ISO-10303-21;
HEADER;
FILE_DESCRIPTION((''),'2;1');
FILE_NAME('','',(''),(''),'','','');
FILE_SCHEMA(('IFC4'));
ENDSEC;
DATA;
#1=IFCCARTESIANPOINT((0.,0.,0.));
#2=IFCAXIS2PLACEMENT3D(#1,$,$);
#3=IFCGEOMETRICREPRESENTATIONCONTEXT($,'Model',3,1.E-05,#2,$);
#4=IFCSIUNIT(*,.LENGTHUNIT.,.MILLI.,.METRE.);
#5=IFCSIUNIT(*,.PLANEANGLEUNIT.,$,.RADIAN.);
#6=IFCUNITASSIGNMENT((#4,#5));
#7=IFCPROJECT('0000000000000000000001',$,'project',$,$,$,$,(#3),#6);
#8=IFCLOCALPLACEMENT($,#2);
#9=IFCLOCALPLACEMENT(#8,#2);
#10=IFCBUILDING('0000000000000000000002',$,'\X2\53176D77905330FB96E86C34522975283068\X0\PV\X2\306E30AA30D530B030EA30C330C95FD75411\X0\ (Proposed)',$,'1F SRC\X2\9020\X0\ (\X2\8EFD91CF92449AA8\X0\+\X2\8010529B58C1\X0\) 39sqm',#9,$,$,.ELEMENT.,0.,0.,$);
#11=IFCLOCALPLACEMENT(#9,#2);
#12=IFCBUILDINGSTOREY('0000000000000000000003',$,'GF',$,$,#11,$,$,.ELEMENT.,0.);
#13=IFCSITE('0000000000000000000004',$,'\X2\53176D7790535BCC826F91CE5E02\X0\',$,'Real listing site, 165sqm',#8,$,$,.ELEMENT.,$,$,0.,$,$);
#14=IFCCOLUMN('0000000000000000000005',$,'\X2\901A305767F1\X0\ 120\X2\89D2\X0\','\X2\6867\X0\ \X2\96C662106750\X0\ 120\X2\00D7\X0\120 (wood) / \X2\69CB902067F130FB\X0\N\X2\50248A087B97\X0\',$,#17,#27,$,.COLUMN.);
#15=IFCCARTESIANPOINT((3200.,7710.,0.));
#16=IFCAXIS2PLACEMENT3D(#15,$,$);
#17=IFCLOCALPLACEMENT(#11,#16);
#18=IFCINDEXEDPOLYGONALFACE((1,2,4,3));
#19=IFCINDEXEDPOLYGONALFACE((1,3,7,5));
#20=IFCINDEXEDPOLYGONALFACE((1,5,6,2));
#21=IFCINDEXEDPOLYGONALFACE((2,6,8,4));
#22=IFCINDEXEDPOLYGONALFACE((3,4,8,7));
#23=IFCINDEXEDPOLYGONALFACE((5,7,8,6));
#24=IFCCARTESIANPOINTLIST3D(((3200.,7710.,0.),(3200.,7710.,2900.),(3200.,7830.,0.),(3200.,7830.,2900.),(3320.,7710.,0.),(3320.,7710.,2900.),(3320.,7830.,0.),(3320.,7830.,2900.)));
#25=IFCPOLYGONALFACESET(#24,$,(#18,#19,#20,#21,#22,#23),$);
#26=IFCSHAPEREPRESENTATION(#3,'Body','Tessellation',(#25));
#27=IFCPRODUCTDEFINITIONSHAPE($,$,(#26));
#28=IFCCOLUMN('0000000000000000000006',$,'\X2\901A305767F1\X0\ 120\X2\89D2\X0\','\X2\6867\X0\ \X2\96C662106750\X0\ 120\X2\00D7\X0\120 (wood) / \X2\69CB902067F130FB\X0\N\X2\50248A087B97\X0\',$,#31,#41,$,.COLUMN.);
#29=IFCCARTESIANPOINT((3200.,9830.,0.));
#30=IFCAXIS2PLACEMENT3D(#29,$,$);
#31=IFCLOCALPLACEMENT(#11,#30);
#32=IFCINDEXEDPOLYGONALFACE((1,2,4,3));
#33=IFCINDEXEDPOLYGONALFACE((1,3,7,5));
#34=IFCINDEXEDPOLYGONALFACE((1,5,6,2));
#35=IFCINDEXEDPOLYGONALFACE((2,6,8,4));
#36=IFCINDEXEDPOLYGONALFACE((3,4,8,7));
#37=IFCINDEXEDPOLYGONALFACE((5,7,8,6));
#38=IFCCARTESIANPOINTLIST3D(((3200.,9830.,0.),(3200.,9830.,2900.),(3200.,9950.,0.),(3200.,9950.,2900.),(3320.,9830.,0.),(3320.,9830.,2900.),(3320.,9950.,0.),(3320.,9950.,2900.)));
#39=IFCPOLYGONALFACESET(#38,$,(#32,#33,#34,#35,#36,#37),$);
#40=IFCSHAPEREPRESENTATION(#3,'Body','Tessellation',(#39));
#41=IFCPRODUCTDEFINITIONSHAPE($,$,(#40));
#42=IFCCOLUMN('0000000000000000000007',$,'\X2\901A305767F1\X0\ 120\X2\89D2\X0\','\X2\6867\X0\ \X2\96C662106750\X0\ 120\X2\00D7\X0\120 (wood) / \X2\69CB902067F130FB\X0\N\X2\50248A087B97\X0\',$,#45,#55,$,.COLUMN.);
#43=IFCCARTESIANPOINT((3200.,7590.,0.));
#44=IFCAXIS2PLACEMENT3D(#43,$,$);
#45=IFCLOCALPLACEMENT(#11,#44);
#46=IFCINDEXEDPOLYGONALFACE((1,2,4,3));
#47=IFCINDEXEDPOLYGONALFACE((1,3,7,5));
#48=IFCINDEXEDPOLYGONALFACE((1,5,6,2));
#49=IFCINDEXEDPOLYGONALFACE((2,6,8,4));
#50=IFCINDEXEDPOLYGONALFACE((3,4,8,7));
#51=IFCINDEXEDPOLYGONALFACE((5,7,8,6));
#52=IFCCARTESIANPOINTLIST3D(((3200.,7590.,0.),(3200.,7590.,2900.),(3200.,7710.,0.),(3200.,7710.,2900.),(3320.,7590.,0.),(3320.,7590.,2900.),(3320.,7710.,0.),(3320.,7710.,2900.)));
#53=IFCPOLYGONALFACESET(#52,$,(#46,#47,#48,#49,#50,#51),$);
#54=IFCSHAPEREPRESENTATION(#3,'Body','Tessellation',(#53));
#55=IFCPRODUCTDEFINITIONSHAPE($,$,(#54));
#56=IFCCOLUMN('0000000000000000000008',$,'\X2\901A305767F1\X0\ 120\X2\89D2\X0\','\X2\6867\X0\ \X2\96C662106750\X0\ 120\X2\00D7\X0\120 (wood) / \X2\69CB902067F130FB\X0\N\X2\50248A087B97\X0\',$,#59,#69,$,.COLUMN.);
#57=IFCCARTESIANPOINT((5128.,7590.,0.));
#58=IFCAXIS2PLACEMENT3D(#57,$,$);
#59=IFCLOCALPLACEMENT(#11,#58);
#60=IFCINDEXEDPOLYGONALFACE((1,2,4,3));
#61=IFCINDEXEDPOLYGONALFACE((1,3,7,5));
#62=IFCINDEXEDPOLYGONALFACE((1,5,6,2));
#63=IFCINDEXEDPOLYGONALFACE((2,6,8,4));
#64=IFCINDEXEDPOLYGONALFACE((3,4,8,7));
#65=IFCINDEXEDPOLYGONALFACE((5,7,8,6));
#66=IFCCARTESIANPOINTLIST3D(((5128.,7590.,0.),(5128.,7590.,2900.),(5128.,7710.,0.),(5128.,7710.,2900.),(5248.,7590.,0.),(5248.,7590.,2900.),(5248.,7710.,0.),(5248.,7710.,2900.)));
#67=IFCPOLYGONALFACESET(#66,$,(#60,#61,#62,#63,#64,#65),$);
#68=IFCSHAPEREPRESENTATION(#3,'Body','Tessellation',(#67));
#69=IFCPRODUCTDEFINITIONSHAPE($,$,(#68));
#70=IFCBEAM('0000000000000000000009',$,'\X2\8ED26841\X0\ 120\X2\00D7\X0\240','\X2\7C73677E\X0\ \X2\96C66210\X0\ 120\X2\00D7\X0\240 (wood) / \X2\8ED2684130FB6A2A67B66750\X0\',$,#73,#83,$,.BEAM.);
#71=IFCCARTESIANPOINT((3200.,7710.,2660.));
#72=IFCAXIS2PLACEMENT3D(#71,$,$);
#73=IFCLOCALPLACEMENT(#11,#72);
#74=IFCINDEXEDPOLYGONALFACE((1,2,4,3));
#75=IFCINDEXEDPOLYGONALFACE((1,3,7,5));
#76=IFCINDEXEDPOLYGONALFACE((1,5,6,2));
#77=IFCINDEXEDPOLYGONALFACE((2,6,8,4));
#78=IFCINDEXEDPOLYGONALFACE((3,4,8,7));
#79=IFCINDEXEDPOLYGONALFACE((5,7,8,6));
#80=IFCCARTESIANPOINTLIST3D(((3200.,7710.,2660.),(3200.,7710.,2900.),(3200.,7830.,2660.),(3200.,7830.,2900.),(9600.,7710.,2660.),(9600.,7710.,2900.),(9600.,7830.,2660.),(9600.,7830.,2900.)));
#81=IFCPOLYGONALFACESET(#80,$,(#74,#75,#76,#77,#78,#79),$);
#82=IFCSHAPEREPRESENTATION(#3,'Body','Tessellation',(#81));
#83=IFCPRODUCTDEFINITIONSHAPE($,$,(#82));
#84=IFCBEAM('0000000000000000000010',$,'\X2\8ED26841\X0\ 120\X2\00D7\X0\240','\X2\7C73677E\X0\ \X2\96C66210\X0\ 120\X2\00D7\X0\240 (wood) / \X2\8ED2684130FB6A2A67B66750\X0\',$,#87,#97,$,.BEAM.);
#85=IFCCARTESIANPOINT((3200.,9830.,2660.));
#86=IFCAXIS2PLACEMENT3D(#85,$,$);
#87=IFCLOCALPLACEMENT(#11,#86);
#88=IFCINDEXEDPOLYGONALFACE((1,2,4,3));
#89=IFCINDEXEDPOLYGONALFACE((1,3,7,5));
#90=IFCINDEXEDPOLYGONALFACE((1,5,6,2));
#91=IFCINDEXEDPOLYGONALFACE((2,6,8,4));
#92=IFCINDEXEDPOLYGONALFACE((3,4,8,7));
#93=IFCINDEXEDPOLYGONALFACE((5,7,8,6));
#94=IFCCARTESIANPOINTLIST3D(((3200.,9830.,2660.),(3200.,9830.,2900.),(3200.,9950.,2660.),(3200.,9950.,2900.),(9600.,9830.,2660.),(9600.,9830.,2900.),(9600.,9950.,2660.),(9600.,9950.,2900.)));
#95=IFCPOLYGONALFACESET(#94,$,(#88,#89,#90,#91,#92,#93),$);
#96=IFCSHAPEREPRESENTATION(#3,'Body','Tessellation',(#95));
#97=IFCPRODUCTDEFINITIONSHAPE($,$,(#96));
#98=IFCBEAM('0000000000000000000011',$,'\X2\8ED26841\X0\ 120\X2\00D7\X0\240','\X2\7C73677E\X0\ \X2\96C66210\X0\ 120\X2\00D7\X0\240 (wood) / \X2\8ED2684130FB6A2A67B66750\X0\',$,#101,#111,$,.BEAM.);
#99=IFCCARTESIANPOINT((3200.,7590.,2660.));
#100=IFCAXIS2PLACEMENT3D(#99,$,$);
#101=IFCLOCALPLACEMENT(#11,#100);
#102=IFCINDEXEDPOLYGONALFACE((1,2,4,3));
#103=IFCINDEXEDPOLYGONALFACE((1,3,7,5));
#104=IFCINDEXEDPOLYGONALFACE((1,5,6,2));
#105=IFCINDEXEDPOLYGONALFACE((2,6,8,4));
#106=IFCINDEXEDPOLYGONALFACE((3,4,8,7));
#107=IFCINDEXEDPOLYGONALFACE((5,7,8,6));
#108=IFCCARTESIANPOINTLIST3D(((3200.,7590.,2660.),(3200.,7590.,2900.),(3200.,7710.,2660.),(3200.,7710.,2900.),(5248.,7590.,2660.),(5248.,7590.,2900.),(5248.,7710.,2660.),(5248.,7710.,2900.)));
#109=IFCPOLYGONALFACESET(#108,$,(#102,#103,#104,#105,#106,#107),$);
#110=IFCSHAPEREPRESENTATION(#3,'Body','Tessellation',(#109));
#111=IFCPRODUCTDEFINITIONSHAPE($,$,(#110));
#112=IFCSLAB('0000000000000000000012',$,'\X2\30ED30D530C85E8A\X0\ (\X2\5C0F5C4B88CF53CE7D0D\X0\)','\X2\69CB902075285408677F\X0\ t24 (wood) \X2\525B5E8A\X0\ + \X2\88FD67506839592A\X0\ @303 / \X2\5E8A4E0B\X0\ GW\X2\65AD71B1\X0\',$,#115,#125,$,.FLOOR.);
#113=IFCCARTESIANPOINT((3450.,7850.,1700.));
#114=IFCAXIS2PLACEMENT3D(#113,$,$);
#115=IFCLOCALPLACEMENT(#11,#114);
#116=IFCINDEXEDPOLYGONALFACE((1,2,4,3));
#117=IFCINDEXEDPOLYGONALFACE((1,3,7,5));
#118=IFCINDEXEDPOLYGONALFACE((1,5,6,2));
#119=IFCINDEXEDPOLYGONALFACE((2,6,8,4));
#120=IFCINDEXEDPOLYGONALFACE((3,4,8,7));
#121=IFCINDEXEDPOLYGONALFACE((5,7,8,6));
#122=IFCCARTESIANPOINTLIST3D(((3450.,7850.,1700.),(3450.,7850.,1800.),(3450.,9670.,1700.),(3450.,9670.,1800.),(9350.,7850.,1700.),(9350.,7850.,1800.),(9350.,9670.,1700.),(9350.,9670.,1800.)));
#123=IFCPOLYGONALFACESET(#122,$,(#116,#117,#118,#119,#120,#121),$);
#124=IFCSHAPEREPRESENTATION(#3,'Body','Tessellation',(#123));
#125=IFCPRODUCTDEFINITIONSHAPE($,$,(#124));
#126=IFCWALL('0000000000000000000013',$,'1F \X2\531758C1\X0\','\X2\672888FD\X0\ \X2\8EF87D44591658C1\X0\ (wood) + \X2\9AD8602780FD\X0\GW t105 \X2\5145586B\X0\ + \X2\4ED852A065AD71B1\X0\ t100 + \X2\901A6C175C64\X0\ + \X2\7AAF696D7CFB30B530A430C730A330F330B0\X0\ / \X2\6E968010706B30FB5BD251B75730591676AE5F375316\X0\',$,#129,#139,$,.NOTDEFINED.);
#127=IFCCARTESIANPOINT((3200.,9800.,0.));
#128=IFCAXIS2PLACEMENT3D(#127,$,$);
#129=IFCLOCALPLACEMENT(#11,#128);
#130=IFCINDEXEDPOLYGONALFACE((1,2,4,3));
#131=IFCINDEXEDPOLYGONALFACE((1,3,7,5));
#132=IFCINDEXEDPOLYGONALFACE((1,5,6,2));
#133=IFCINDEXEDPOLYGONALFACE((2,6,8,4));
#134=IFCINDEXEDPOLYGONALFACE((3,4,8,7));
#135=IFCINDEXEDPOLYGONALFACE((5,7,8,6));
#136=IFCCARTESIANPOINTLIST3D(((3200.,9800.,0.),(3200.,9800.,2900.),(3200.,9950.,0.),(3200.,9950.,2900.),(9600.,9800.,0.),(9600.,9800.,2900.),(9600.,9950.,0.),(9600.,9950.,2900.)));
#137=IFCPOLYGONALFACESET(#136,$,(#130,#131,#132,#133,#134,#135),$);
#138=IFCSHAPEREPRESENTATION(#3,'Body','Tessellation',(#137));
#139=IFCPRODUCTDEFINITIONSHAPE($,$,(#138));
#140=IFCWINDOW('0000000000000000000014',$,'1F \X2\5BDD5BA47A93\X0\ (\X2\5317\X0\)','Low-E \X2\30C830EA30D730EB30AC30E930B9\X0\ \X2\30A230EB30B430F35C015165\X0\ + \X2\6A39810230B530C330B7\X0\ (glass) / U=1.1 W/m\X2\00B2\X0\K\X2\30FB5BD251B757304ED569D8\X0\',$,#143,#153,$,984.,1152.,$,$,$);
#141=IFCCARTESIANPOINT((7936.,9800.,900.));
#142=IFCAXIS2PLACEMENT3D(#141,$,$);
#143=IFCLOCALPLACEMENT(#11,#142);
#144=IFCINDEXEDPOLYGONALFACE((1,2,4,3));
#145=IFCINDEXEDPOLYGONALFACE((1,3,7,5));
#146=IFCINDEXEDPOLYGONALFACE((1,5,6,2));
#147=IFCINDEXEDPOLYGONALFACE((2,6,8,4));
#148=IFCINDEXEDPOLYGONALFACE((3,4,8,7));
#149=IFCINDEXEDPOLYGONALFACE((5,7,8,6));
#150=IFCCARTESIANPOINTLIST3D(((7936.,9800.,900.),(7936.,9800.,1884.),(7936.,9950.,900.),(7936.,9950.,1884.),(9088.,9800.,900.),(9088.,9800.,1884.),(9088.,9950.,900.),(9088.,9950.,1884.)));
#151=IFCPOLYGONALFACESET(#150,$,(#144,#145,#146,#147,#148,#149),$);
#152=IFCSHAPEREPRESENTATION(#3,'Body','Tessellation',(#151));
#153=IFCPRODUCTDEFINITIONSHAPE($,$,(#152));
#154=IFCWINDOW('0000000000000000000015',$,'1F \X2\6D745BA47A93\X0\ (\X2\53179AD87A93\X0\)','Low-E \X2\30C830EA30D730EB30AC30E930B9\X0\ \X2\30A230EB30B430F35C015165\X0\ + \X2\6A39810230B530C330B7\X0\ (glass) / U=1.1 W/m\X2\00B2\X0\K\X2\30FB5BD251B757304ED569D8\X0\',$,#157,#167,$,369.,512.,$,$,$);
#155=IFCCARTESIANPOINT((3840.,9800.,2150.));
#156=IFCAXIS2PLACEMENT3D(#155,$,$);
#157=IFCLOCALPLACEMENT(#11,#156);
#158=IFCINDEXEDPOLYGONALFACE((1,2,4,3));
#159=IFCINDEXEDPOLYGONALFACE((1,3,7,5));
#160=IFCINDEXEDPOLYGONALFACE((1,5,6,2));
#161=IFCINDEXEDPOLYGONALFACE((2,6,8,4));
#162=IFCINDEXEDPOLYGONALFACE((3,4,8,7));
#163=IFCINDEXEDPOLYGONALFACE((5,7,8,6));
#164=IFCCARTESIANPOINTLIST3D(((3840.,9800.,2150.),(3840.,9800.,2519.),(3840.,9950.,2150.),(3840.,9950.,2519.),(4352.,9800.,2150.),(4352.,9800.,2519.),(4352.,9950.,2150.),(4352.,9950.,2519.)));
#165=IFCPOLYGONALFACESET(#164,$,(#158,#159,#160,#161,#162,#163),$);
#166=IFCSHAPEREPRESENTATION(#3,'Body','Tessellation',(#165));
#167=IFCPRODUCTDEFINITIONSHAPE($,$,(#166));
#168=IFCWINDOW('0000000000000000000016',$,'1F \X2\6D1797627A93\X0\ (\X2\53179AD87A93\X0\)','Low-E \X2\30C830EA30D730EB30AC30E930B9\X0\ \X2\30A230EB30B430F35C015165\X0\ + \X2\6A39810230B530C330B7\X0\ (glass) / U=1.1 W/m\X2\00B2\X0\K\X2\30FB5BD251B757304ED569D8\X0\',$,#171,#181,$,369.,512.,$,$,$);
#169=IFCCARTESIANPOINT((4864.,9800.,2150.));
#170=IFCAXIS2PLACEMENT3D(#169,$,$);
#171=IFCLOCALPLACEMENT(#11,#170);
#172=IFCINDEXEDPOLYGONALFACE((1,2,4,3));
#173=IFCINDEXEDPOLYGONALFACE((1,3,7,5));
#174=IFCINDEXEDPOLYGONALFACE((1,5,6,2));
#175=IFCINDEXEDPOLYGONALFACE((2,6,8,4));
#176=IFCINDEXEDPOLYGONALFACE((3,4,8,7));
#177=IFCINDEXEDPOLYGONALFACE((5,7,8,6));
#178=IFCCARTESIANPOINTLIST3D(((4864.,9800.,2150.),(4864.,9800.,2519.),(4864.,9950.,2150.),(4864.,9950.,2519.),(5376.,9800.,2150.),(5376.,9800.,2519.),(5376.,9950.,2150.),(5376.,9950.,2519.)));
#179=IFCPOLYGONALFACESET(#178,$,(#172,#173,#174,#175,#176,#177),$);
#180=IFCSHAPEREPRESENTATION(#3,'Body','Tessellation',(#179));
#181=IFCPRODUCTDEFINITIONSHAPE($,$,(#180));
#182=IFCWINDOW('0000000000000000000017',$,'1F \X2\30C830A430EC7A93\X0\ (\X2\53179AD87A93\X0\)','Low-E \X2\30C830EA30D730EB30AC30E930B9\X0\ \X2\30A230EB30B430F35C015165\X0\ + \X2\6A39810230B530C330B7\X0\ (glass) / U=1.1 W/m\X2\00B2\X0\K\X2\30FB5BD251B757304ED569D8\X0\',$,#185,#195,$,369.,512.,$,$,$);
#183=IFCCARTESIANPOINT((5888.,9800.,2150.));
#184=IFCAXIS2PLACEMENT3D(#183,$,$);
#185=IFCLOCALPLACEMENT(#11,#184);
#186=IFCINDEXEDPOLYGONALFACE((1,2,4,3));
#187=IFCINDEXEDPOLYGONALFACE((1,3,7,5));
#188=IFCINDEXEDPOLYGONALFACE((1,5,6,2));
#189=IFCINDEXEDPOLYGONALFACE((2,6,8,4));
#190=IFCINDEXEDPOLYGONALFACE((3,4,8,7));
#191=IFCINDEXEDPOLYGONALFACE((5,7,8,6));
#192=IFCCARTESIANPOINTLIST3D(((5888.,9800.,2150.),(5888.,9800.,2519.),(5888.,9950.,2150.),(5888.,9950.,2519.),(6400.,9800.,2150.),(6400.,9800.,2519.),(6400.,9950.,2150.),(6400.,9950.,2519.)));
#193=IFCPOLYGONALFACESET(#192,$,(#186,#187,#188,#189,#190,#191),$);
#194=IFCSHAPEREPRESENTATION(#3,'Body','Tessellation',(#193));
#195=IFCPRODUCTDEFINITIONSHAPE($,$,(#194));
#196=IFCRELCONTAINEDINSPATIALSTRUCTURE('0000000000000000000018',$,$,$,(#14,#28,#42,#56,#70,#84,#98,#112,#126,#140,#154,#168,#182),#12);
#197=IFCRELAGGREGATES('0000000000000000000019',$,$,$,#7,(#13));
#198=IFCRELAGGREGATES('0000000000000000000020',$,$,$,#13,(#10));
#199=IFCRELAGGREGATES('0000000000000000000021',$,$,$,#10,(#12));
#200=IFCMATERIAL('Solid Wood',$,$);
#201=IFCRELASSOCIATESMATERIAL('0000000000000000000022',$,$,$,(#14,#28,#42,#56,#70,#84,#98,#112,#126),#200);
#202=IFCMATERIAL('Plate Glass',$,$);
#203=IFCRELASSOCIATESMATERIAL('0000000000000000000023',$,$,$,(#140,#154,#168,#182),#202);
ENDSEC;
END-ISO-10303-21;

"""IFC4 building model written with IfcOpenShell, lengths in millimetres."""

from ifc_helpers import new_model, si_unit, frame, frame_2d, origin, place, context, project, spatial, rectangle, extrude, material, element, fill, save


model = new_model("IFC4")

# Units and contexts
model_context = context("Model", 3, precision=1e-05, world=origin())
ifc_project = project(units=[si_unit("LENGTHUNIT", "METRE", prefix="MILLI"), si_unit("PLANEANGLEUNIT", "RADIAN")], contexts=[model_context])

# Site, building, storey
site_placement = place(None, origin())
site = spatial("IfcSite", under=ifc_project, at=site_placement, Name="北海道富良野市", ObjectType="Real listing site, 165sqm", CompositionType="ELEMENT", RefElevation=0.0)
building_placement = place(site_placement, origin())
building = spatial("IfcBuilding", under=site, at=building_placement, Name="北海道・雨水利用とPVのオフグリッド志向 (Proposed)", ObjectType="1F SRC造 (軽量鉄骨+耐力壁) 39sqm", CompositionType="ELEMENT", ElevationOfRefHeight=0.0, ElevationOfTerrain=0.0)
storey_placement = place(building_placement, origin())
storey = spatial("IfcBuildingStorey", under=building, at=storey_placement, Name="GF", CompositionType="ELEMENT", Elevation=0.0)

# Columns
ifc_material_1 = material(Name="Solid Wood")
column_1_placement = place(storey_placement, frame((3200.0, 7710.0, 0.0)))
element("IfcColumn", 1, at=column_1_placement, inside=storey, material=ifc_material_1, Name="通し柱 120角", Description="桧 集成材 120×120 (wood) / 構造柱・N値計算", PredefinedType="COLUMN", context=model_context, shape_type="SweptSolid", body=[
    extrude(rectangle(XDim=120.0, YDim=120.0, at=frame_2d((60.0, 60.0))), frame((3200.0, 7710.0, 0.0)), (0.0, 0.0, 1.0), 2900.0),
])
column_2_placement = place(storey_placement, frame((3200.0, 9830.0, 0.0)))
element("IfcColumn", 2, at=column_2_placement, inside=storey, material=ifc_material_1, Name="通し柱 120角", Description="桧 集成材 120×120 (wood) / 構造柱・N値計算", PredefinedType="COLUMN", context=model_context, shape_type="SweptSolid", body=[
    extrude(rectangle(XDim=120.0, YDim=120.0, at=frame_2d((60.0, 60.0))), frame((3200.0, 9830.0, 0.0)), (0.0, 0.0, 1.0), 2900.0),
])
column_3_placement = place(storey_placement, frame((3200.0, 7590.0, 0.0)))
element("IfcColumn", 3, at=column_3_placement, inside=storey, material=ifc_material_1, Name="通し柱 120角", Description="桧 集成材 120×120 (wood) / 構造柱・N値計算", PredefinedType="COLUMN", context=model_context, shape_type="SweptSolid", body=[
    extrude(rectangle(XDim=120.0, YDim=120.0, at=frame_2d((60.0, 60.0))), frame((3200.0, 7590.0, 0.0)), (0.0, 0.0, 1.0), 2900.0),
])
column_4_placement = place(storey_placement, frame((5128.0, 7590.0, 0.0)))
element("IfcColumn", 4, at=column_4_placement, inside=storey, material=ifc_material_1, Name="通し柱 120角", Description="桧 集成材 120×120 (wood) / 構造柱・N値計算", PredefinedType="COLUMN", context=model_context, shape_type="SweptSolid", body=[
    extrude(rectangle(XDim=120.0, YDim=120.0, at=frame_2d((60.0, 60.0))), frame((5128.0, 7590.0, 0.0)), (0.0, 0.0, 1.0), 2900.0),
])

# Beams
beam_1_placement = place(storey_placement, frame((3200.0, 7710.0, 2660.0)))
element("IfcBeam", 5, at=beam_1_placement, inside=storey, material=ifc_material_1, Name="軒桁 120×240", Description="米松 集成 120×240 (wood) / 軒桁・横架材", PredefinedType="BEAM", context=model_context, shape_type="SweptSolid", body=[
    extrude(rectangle(XDim=6400.0, YDim=120.0, at=frame_2d((3200.0, 60.0))), frame((3200.0, 7710.0, 2660.0)), (0.0, 0.0, 1.0), 240.0),
])
beam_2_placement = place(storey_placement, frame((3200.0, 9830.0, 2660.0)))
element("IfcBeam", 6, at=beam_2_placement, inside=storey, material=ifc_material_1, Name="軒桁 120×240", Description="米松 集成 120×240 (wood) / 軒桁・横架材", PredefinedType="BEAM", context=model_context, shape_type="SweptSolid", body=[
    extrude(rectangle(XDim=6400.0, YDim=120.0, at=frame_2d((3200.0, 60.0))), frame((3200.0, 9830.0, 2660.0)), (0.0, 0.0, 1.0), 240.0),
])
beam_3_placement = place(storey_placement, frame((3200.0, 7590.0, 2660.0)))
element("IfcBeam", 7, at=beam_3_placement, inside=storey, material=ifc_material_1, Name="軒桁 120×240", Description="米松 集成 120×240 (wood) / 軒桁・横架材", PredefinedType="BEAM", context=model_context, shape_type="SweptSolid", body=[
    extrude(rectangle(XDim=2048.0, YDim=120.0, at=frame_2d((1024.0, 60.0))), frame((3200.0, 7590.0, 2660.0)), (0.0, 0.0, 1.0), 240.0),
])

# Slab
slab_1_placement = place(storey_placement, frame((3450.0, 7850.0, 1700.0)))
element("IfcSlab", 8, at=slab_1_placement, inside=storey, material=ifc_material_1, Name="ロフト床 (小屋裏収納)", Description="構造用合板 t24 (wood) 剛床 + 製材根太 @303 / 床下 GW断熱", PredefinedType="FLOOR", context=model_context, shape_type="SweptSolid", body=[
    extrude(rectangle(XDim=5900.0, YDim=1820.0, at=frame_2d((2950.0, 910.0))), frame((3450.0, 7850.0, 1700.0)), (0.0, 0.0, 1.0), 100.0),
])

# Wall, openings, windows
wall_1_placement = place(storey_placement, frame((3200.0, 9800.0, 0.0)))
wall_1 = element("IfcWall", 9, at=wall_1_placement, inside=storey, material=ifc_material_1, Name="1F 北壁", Description="木製 軸組外壁 (wood) + 高性能GW t105 充填 + 付加断熱 t100 + 通気層 + 窯業系サイディング / 準耐火・寒冷地外皮強化", PredefinedType="NOTDEFINED", context=model_context, shape_type="SweptSolid", body=[
    extrude(rectangle(XDim=6400.0, YDim=150.0, at=frame_2d((3200.0, 75.0))), frame((3200.0, 9800.0, 0.0)), (0.0, 0.0, 1.0), 2900.0),
])
opening_1_placement = place(storey_placement, frame((7936.0, 9800.0, 900.0)))
opening_1 = element("IfcOpeningElement", 10, at=opening_1_placement, cuts=wall_1, PredefinedType="NOTDEFINED", context=model_context, shape_type="SweptSolid", body=[
    extrude(rectangle(XDim=1152.0, YDim=150.0, at=frame_2d((576.0, 75.0))), frame((7936.0, 9800.0, 900.0)), (0.0, 0.0, 1.0), 984.0),
])
opening_2_placement = place(storey_placement, frame((3840.0, 9800.0, 2150.0)))
opening_2 = element("IfcOpeningElement", 11, at=opening_2_placement, cuts=wall_1, PredefinedType="NOTDEFINED", context=model_context, shape_type="SweptSolid", body=[
    extrude(rectangle(XDim=512.0, YDim=150.0, at=frame_2d((256.0, 75.0))), frame((3840.0, 9800.0, 2150.0)), (0.0, 0.0, 1.0), 369.0),
])
opening_3_placement = place(storey_placement, frame((4864.0, 9800.0, 2150.0)))
opening_3 = element("IfcOpeningElement", 12, at=opening_3_placement, cuts=wall_1, PredefinedType="NOTDEFINED", context=model_context, shape_type="SweptSolid", body=[
    extrude(rectangle(XDim=512.0, YDim=150.0, at=frame_2d((256.0, 75.0))), frame((4864.0, 9800.0, 2150.0)), (0.0, 0.0, 1.0), 369.0),
])
opening_4_placement = place(storey_placement, frame((5888.0, 9800.0, 2150.0)))
opening_4 = element("IfcOpeningElement", 13, at=opening_4_placement, cuts=wall_1, PredefinedType="NOTDEFINED", context=model_context, shape_type="SweptSolid", body=[
    extrude(rectangle(XDim=512.0, YDim=150.0, at=frame_2d((256.0, 75.0))), frame((5888.0, 9800.0, 2150.0)), (0.0, 0.0, 1.0), 369.0),
])
ifc_material_2 = material(Name="Plate Glass")
window_1_placement = place(storey_placement, frame((7936.0, 9800.0, 900.0)))
window_1 = element("IfcWindow", 14, at=window_1_placement, inside=storey, material=ifc_material_2, Name="1F 寝室窓 (北)", Description="Low-E トリプルガラス アルゴン封入 + 樹脂サッシ (glass) / U=1.1 W/m²K・寒冷地仕様", OverallHeight=984.0, OverallWidth=1152.0, context=model_context, shape_type="SweptSolid", body=[
    extrude(rectangle(XDim=1152.0, YDim=150.0, at=frame_2d((576.0, 75.0))), frame((7936.0, 9800.0, 900.0)), (0.0, 0.0, 1.0), 984.0),
])
fill(opening_1, window_1)
window_2_placement = place(storey_placement, frame((3840.0, 9800.0, 2150.0)))
window_2 = element("IfcWindow", 15, at=window_2_placement, inside=storey, material=ifc_material_2, Name="1F 浴室窓 (北高窓)", Description="Low-E トリプルガラス アルゴン封入 + 樹脂サッシ (glass) / U=1.1 W/m²K・寒冷地仕様", OverallHeight=369.0, OverallWidth=512.0, context=model_context, shape_type="SweptSolid", body=[
    extrude(rectangle(XDim=512.0, YDim=150.0, at=frame_2d((256.0, 75.0))), frame((3840.0, 9800.0, 2150.0)), (0.0, 0.0, 1.0), 369.0),
])
fill(opening_2, window_2)
window_3_placement = place(storey_placement, frame((4864.0, 9800.0, 2150.0)))
window_3 = element("IfcWindow", 16, at=window_3_placement, inside=storey, material=ifc_material_2, Name="1F 洗面窓 (北高窓)", Description="Low-E トリプルガラス アルゴン封入 + 樹脂サッシ (glass) / U=1.1 W/m²K・寒冷地仕様", OverallHeight=369.0, OverallWidth=512.0, context=model_context, shape_type="SweptSolid", body=[
    extrude(rectangle(XDim=512.0, YDim=150.0, at=frame_2d((256.0, 75.0))), frame((4864.0, 9800.0, 2150.0)), (0.0, 0.0, 1.0), 369.0),
])
fill(opening_3, window_3)
window_4_placement = place(storey_placement, frame((5888.0, 9800.0, 2150.0)))
window_4 = element("IfcWindow", 17, at=window_4_placement, inside=storey, material=ifc_material_2, Name="1F トイレ窓 (北高窓)", Description="Low-E トリプルガラス アルゴン封入 + 樹脂サッシ (glass) / U=1.1 W/m²K・寒冷地仕様", OverallHeight=369.0, OverallWidth=512.0, context=model_context, shape_type="SweptSolid", body=[
    extrude(rectangle(XDim=512.0, YDim=150.0, at=frame_2d((256.0, 75.0))), frame((5888.0, 9800.0, 2150.0)), (0.0, 0.0, 1.0), 369.0),
])
fill(opening_4, window_4)

save(model, "model.ifc")
